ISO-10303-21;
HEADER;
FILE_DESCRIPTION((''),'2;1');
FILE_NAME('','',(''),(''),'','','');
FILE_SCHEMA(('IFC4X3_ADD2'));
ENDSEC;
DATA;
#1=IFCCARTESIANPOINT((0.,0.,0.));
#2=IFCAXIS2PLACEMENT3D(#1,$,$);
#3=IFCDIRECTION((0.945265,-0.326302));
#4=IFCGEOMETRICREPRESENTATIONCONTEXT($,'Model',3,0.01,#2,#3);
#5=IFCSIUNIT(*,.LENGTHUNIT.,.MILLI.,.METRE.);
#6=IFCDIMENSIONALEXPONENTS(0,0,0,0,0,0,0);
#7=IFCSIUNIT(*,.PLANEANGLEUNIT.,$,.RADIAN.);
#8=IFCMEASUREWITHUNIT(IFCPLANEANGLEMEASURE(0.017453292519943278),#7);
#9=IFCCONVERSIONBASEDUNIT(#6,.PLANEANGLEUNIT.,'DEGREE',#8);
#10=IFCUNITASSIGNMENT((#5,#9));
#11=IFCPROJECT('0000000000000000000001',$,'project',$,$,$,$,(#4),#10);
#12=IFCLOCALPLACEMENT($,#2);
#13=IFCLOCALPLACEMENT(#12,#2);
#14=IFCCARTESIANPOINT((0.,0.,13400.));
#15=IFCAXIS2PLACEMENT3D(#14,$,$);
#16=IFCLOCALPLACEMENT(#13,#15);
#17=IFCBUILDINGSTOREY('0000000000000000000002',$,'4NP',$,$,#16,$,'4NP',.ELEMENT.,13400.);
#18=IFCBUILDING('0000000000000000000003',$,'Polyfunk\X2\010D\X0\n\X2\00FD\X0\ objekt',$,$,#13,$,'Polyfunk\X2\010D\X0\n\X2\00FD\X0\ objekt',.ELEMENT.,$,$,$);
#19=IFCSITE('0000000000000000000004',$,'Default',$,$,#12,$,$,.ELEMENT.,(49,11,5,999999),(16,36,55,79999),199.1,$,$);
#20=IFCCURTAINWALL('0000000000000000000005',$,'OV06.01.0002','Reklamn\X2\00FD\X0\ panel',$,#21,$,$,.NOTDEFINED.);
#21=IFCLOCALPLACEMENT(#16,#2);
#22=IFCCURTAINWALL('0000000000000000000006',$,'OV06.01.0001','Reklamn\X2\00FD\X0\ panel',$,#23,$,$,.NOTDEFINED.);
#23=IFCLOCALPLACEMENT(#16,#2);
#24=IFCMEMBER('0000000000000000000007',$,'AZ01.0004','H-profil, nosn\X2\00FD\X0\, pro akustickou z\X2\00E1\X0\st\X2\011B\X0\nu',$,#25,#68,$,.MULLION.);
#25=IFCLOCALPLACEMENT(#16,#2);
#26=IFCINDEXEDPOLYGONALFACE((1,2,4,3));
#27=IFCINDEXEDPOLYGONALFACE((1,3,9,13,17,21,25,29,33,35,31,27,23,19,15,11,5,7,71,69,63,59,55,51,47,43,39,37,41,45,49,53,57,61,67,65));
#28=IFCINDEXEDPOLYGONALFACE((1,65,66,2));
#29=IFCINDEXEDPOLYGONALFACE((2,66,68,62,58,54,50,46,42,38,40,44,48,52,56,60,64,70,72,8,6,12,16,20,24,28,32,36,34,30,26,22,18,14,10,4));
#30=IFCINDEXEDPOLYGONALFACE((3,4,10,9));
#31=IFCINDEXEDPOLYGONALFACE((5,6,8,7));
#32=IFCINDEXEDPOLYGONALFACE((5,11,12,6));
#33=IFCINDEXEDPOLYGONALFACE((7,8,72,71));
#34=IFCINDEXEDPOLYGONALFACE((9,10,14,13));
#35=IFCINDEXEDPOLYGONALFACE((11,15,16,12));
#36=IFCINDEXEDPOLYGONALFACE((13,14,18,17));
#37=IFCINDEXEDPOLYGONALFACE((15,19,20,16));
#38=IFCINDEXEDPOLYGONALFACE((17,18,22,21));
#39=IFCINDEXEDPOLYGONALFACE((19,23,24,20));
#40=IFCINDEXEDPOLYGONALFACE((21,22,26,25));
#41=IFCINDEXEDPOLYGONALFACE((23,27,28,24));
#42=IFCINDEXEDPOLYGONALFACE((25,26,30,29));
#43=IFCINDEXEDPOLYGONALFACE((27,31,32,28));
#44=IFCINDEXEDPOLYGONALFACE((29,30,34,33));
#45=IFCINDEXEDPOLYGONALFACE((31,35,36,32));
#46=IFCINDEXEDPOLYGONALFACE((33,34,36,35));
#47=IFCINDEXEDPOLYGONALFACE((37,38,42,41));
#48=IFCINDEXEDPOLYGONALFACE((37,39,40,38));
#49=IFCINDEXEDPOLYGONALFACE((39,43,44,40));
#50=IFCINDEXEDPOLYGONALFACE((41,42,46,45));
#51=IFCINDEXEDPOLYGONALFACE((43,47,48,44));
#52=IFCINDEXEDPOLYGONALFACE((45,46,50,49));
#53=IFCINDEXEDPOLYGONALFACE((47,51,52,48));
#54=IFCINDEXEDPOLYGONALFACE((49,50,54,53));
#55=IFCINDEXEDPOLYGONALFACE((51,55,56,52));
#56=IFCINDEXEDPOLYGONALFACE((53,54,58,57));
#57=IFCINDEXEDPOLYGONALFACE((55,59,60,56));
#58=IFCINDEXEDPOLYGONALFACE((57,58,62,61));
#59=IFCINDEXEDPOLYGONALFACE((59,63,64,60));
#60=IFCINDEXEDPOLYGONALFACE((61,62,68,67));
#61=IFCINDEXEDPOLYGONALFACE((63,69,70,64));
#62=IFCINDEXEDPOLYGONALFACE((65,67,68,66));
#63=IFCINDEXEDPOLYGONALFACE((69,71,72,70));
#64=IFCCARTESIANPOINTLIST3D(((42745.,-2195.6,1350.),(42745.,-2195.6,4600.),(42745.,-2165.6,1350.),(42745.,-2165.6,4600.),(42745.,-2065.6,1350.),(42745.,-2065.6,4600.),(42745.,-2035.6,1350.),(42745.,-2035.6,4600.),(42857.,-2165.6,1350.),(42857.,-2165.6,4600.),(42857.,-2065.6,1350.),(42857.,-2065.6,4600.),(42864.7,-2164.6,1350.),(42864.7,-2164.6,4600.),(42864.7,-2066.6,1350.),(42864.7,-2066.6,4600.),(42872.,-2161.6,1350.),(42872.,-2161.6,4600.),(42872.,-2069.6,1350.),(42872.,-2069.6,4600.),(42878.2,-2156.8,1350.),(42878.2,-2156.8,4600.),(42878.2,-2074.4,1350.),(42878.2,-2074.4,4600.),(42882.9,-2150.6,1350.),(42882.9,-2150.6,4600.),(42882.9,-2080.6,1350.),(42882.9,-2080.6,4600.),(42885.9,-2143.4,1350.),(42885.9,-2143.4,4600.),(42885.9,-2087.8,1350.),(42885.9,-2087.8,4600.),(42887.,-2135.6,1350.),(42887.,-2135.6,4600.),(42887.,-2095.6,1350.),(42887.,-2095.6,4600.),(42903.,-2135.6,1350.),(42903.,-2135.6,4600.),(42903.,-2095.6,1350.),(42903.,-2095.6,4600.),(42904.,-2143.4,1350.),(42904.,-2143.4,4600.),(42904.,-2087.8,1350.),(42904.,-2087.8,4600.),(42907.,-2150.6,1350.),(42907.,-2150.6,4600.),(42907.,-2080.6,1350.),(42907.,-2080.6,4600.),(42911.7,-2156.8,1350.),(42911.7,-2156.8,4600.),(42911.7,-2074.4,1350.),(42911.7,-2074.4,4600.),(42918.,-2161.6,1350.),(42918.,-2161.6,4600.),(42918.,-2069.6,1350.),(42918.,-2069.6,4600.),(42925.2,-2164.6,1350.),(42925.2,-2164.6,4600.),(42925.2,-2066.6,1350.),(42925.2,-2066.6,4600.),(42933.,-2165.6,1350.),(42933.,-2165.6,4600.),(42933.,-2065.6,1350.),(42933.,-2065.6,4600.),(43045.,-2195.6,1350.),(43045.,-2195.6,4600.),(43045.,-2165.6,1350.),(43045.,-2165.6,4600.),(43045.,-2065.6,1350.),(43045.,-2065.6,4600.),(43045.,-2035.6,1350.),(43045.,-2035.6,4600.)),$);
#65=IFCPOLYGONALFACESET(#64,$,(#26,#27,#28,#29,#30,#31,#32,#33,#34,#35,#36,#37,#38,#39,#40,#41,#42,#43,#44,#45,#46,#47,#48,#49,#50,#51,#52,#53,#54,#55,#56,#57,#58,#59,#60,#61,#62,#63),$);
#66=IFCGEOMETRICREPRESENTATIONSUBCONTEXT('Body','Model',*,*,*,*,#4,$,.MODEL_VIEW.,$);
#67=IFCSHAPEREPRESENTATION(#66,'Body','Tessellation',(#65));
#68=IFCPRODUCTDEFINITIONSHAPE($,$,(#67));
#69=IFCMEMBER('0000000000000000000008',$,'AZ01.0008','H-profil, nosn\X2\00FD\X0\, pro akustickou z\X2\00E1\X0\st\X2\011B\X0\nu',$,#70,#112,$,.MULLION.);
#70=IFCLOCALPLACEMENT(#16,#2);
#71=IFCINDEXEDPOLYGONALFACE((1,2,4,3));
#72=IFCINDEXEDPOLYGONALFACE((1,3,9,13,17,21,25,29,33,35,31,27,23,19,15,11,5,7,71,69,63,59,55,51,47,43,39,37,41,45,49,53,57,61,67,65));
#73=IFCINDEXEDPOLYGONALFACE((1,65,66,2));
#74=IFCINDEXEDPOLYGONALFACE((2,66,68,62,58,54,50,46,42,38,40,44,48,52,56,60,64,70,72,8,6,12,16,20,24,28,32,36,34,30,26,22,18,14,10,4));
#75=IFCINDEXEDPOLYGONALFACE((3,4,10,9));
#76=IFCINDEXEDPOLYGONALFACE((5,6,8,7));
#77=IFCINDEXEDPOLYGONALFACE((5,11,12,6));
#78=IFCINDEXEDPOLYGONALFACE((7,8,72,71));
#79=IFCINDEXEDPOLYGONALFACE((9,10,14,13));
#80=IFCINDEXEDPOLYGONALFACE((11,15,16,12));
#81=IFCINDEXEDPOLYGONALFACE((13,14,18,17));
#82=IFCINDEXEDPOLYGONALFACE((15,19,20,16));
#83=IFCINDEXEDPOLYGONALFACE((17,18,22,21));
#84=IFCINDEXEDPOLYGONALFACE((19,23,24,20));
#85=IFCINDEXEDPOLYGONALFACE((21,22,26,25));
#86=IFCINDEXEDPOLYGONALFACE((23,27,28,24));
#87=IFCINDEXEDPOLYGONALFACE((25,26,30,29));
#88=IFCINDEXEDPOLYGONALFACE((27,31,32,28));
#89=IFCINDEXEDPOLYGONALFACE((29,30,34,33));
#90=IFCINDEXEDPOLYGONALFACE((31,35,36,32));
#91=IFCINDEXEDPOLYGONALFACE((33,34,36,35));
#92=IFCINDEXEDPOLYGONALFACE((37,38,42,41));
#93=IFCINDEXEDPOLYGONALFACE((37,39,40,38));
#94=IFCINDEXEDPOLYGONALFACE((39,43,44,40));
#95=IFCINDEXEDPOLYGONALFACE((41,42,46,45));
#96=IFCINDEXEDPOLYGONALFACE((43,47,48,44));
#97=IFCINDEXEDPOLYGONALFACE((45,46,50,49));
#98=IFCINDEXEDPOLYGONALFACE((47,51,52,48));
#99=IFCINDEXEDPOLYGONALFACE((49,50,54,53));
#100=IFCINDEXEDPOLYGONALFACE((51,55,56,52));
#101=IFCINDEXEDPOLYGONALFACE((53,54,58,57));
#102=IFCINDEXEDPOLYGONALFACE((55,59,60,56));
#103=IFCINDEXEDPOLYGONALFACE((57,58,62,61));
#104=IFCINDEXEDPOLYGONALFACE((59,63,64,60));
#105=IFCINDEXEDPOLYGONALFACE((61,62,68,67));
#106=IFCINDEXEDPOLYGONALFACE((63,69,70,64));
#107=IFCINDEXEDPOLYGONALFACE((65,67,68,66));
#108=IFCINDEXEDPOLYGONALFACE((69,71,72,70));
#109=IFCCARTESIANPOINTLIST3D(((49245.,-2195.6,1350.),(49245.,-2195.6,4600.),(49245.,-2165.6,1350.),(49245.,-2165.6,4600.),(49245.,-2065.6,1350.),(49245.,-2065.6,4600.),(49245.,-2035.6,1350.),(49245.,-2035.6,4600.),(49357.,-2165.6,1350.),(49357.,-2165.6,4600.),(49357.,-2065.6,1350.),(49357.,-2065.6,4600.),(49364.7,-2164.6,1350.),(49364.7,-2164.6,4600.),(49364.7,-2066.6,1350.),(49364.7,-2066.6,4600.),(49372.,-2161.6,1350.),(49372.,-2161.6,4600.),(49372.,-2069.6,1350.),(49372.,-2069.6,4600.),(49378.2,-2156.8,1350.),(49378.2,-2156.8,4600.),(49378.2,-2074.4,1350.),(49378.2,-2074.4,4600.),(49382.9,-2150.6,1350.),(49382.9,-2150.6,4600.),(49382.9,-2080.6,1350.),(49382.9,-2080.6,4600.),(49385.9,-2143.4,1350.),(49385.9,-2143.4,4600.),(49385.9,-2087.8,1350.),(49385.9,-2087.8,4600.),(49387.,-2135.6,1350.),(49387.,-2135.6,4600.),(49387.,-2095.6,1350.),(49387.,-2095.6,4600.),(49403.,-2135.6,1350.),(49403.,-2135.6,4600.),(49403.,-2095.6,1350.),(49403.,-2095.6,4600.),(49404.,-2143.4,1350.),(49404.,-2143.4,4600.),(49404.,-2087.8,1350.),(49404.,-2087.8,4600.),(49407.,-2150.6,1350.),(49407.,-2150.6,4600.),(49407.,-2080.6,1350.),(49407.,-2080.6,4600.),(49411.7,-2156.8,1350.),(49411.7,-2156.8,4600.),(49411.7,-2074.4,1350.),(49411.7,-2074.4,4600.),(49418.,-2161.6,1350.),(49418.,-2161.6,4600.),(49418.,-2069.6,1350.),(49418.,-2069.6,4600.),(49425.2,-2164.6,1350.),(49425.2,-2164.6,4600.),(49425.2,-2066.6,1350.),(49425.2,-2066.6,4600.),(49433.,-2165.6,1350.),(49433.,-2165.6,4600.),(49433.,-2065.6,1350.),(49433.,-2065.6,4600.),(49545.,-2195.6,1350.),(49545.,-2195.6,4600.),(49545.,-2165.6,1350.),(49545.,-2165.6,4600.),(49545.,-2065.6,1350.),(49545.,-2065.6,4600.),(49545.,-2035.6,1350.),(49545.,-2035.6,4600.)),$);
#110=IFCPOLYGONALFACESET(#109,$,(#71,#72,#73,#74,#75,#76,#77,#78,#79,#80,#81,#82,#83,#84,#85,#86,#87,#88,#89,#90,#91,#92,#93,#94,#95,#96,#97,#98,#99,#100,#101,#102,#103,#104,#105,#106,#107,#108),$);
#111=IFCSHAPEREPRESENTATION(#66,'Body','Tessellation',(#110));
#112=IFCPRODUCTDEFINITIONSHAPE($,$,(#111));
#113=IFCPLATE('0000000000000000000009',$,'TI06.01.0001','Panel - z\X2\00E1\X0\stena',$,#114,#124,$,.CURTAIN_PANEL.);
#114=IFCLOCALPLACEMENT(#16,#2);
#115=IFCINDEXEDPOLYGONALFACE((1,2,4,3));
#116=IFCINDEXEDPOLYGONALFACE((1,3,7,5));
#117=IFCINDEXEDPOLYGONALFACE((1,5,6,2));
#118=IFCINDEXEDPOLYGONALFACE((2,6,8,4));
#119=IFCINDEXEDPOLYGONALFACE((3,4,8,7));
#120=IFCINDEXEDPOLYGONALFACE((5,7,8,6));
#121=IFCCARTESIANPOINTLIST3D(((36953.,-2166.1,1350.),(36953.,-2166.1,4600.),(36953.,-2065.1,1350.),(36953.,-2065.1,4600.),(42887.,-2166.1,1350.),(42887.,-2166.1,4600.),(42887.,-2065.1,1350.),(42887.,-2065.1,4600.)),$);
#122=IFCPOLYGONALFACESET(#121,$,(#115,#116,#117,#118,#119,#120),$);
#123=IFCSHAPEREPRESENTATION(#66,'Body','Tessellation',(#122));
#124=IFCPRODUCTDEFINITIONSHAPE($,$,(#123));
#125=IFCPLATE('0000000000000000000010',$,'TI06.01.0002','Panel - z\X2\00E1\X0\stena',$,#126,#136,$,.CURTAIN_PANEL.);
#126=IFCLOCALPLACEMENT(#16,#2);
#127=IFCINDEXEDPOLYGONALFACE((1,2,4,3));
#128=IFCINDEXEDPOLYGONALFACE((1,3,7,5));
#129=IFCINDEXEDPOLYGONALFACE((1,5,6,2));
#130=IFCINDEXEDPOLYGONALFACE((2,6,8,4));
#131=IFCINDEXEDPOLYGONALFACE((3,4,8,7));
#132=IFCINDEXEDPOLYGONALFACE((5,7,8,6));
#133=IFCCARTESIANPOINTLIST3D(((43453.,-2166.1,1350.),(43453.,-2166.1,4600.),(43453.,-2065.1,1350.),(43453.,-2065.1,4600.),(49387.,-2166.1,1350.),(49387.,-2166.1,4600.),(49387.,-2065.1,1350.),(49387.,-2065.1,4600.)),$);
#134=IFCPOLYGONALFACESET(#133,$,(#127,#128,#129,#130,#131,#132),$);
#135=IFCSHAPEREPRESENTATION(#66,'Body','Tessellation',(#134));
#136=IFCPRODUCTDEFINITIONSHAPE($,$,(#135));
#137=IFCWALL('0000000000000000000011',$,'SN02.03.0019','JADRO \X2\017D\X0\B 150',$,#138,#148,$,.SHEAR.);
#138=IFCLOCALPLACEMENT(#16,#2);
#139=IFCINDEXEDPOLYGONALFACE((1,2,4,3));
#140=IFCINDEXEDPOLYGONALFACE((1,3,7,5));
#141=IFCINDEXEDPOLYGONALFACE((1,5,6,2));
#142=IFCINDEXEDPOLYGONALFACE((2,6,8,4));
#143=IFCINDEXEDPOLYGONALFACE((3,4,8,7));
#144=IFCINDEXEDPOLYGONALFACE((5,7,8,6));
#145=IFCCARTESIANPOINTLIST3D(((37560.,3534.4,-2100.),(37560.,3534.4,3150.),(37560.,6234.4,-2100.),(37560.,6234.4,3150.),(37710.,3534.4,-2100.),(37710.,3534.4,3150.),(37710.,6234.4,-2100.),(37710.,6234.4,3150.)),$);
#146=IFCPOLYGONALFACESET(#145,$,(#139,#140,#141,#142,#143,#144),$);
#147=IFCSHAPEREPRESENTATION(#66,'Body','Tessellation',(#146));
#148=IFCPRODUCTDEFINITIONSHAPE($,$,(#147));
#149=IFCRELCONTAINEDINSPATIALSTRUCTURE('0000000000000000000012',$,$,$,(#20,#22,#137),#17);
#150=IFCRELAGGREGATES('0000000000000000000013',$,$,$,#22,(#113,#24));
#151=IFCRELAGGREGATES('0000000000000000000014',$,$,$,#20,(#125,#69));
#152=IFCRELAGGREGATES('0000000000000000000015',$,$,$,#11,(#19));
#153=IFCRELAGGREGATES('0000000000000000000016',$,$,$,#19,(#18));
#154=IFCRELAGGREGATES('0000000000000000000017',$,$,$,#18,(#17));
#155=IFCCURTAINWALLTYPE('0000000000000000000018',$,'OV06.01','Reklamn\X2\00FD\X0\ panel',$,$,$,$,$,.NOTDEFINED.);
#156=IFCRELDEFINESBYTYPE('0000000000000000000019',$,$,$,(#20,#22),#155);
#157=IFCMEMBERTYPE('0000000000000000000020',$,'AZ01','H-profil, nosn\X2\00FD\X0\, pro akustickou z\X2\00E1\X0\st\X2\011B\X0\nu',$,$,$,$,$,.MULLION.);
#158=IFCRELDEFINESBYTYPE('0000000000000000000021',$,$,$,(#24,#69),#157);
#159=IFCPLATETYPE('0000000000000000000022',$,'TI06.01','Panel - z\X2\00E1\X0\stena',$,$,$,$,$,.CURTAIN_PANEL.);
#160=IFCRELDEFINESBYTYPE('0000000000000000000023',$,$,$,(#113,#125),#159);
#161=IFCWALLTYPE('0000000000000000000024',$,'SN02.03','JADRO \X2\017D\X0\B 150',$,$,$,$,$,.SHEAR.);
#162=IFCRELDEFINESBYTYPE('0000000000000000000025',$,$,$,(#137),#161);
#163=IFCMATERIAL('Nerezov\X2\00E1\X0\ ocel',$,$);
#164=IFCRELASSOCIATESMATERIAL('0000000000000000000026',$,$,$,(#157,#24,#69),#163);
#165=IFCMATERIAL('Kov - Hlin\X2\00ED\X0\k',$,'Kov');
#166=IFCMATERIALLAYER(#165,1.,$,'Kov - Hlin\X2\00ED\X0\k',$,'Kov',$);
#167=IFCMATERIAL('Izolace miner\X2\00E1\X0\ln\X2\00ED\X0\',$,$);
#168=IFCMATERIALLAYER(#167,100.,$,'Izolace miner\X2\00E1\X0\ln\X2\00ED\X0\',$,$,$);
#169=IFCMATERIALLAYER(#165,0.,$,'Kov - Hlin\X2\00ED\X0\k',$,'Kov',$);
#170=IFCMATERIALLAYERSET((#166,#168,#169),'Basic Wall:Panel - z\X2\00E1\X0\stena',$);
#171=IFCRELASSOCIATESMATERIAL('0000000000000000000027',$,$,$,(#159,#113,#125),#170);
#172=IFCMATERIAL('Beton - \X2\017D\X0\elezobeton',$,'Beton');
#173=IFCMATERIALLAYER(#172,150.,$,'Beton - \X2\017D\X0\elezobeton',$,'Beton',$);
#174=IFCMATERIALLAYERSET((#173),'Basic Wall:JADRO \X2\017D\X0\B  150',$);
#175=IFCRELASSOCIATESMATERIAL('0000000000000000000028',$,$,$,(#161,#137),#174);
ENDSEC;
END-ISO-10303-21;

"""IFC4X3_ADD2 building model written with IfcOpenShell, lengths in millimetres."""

from ifc_helpers import new_model, entity, si_unit, converted_unit, direction, frame, frame_2d, origin, place, context, subcontext, project, spatial, polyline, circle_curve, parameter, trimmed, segment, composite_curve, rectangle, outline, extrude, source, transform, mapped, material, layer, layer_set, layer_usage, material_profile, profile_set, profile_usage, type_object, element, aggregate, save


model = new_model("IFC4X3_ADD2")

# Units and contexts
model_context = context("Model", 3, precision=0.01, world=origin(), true_north=direction((0.945265, -0.326302)))
body_context = subcontext(model_context, "Body", "Model", "MODEL_VIEW")
ifc_project = project(units=[si_unit("LENGTHUNIT", "METRE", prefix="MILLI"), converted_unit("PLANEANGLEUNIT", "DEGREE", entity("IfcPlaneAngleMeasure", 0.017453292519943278), si_unit("PLANEANGLEUNIT", "RADIAN"), dimensions=[0, 0, 0, 0, 0, 0, 0])], contexts=[model_context])

# Site, building, storey
site_placement = place(None, origin())
site = spatial("IfcSite", under=ifc_project, at=site_placement, Name="Default", CompositionType="ELEMENT", RefLatitude=(49, 11, 5, 999999), RefLongitude=(16, 36, 55, 79999), RefElevation=199.1)
building_placement = place(site_placement, origin())
building = spatial("IfcBuilding", under=site, at=building_placement, Name="Polyfunkčný objekt", LongName="Polyfunkčný objekt", CompositionType="ELEMENT")
storey_placement = place(building_placement, frame((0.0, 0.0, 13400.0)))
storey = spatial("IfcBuildingStorey", under=building, at=storey_placement, Name="4NP", LongName="4NP", CompositionType="ELEMENT", Elevation=13400.0)

# Curtain walls
curtain_wall_type = type_object("IfcCurtainWallType", Name="OV06.01", Description="Reklamný panel", PredefinedType="NOTDEFINED")
curtain_wall_1_placement = place(storey_placement, frame((0.0, 0.0, -13400.0)))
curtain_wall_1 = element("IfcCurtainWall", 1, at=curtain_wall_1_placement, inside=storey, type_object=curtain_wall_type, Name="OV06.01.0002", Description="Reklamný panel", PredefinedType="NOTDEFINED")
ifc_material_1 = material(Name="Nerezová ocel")
ifc_material_profile = material_profile(ifc_material_1, outline(composite_curve([segment(polyline([(50.0, -150.0), (80.0, -150.0)]), True, "CONTINUOUS"), segment(polyline([(80.0, -150.0), (80.0, 150.0)]), True, "CONTINUOUS"), segment(polyline([(80.0, 150.0), (50.0, 150.0)]), True, "CONTINUOUS"), segment(polyline([(50.0, 150.0), (50.0, 38.0)]), True, "CONTINUOUS"), segment(trimmed(circle_curve(frame_2d((20.0, 38.0), x_axis=(0.0, 1.0)), 30.0), [parameter(180.0)], [parameter(270.0)], True, "PARAMETER"), False, "CONTINUOUS"), segment(polyline([(20.0, 8.0), (-20.0, 8.0)]), True, "CONTINUOUS"), segment(trimmed(circle_curve(frame_2d((-20.0, 38.0), x_axis=(0.0, 1.0)), 30.0), [parameter(90.0)], [parameter(180.0)], True, "PARAMETER"), False, "CONTINUOUS"), segment(polyline([(-50.0, 38.0), (-50.0, 150.0)]), True, "CONTINUOUS"), segment(polyline([(-50.0, 150.0), (-80.0, 150.0)]), True, "CONTINUOUS"), segment(polyline([(-80.0, 150.0), (-80.0, -150.0)]), True, "CONTINUOUS"), segment(polyline([(-80.0, -150.0), (-50.0, -150.0)]), True, "CONTINUOUS"), segment(polyline([(-50.0, -150.0), (-50.0, -38.0)]), True, "CONTINUOUS"), segment(trimmed(circle_curve(frame_2d((-20.0, -38.0), x_axis=(0.0, 1.0)), 30.0), [parameter(0.0)], [parameter(90.0)], True, "PARAMETER"), False, "CONTINUOUS"), segment(polyline([(-20.0, -8.0), (20.0, -8.0)]), True, "CONTINUOUS"), segment(trimmed(circle_curve(frame_2d((20.0, -38.0), x_axis=(0.0, 1.0)), 30.0), [parameter(270.0)], [parameter(0.0)], True, "PARAMETER"), False, "CONTINUOUS"), segment(polyline([(50.0, -38.0), (50.0, -150.0)]), True, "CONTINUOUS")], self_intersect=False)), Name="Profil zástena")
ifc_profile_set = profile_set([ifc_material_profile], Name="Profil zástena")
ifc_profile_usage = profile_usage(ifc_profile_set)
member_type_1 = type_object("IfcMemberType", Name="AZ01", Description="H-profil, nosný, pro akustickou zástěnu", PredefinedType="MULLION", material=ifc_profile_set)
curtain_wall_2_placement = place(storey_placement, frame((0.0, 0.0, -13400.0)))
curtain_wall_2 = element("IfcCurtainWall", 2, at=curtain_wall_2_placement, inside=storey, type_object=curtain_wall_type, Name="OV06.01.0001", Description="Reklamný panel", PredefinedType="NOTDEFINED")

# Members
shared_shape_1 = source(origin(), body_context, "Body", "SweptSolid", [
    extrude(outline(composite_curve([segment(polyline([(-150.0, -50.0), (-150.0, -80.0)]), True, "CONTINUOUS"), segment(polyline([(-150.0, -80.0), (150.0, -80.0)]), True, "CONTINUOUS"), segment(polyline([(150.0, -80.0), (150.0, -50.0)]), True, "CONTINUOUS"), segment(polyline([(150.0, -50.0), (38.0, -50.0)]), True, "CONTINUOUS"), segment(trimmed(circle_curve(frame_2d((38.0, -20.0), x_axis=(1.0, 0.0)), 30.0), [parameter(180.0)], [parameter(270.0)], True, "PARAMETER"), False, "CONTINUOUS"), segment(polyline([(8.0, -20.0), (8.0, 20.0)]), True, "CONTINUOUS"), segment(trimmed(circle_curve(frame_2d((38.0, 20.0), x_axis=(1.0, 0.0)), 30.0), [parameter(90.0)], [parameter(180.0)], True, "PARAMETER"), False, "CONTINUOUS"), segment(polyline([(38.0, 50.0), (150.0, 50.0)]), True, "CONTINUOUS"), segment(polyline([(150.0, 50.0), (150.0, 80.0)]), True, "CONTINUOUS"), segment(polyline([(150.0, 80.0), (-150.0, 80.0)]), True, "CONTINUOUS"), segment(polyline([(-150.0, 80.0), (-150.0, 50.0)]), True, "CONTINUOUS"), segment(polyline([(-150.0, 50.0), (-38.0, 50.0)]), True, "CONTINUOUS"), segment(trimmed(circle_curve(frame_2d((-38.0, 20.0), x_axis=(1.0, 0.0)), 30.0), [parameter(0.0)], [parameter(90.0)], True, "PARAMETER"), False, "CONTINUOUS"), segment(polyline([(-8.0, 20.0), (-8.0, -20.0)]), True, "CONTINUOUS"), segment(trimmed(circle_curve(frame_2d((-38.0, -20.0), x_axis=(1.0, 0.0)), 30.0), [parameter(270.0)], [parameter(0.0)], True, "PARAMETER"), False, "CONTINUOUS"), segment(polyline([(-38.0, -50.0), (-150.0, -50.0)]), True, "CONTINUOUS")], self_intersect=False)), frame((-150.0, 0.0, -3250.0), z_axis=(0.0, 0.0, -1.0), x_axis=(1.0, 0.0, 0.0)), (0.0, 0.0, -1.0), 3250.0),
])
member_1_placement = place(curtain_wall_2_placement, frame((43045.0, -2115.6, 14750.0), z_axis=(0.0, 0.0, -1.0), x_axis=(1.0, 0.0, 0.0)))
member_1 = element("IfcMember", 3, at=member_1_placement, type_object=member_type_1, material=ifc_profile_usage, Name="AZ01.0004", Description="H-profil, nosný, pro akustickou zástěnu", PredefinedType="MULLION", context=body_context, shape_type="MappedRepresentation", body=[
    mapped(shared_shape_1, transform((0.0, 0.0, 0.0), scale=1.0)),
])
member_2_placement = place(curtain_wall_1_placement, frame((49545.0, -2115.6, 14750.0), z_axis=(0.0, 0.0, -1.0), x_axis=(1.0, 0.0, 0.0)))
member_2 = element("IfcMember", 4, at=member_2_placement, type_object=member_type_1, material=ifc_profile_usage, Name="AZ01.0008", Description="H-profil, nosný, pro akustickou zástěnu", PredefinedType="MULLION", context=body_context, shape_type="MappedRepresentation", body=[
    mapped(shared_shape_1, transform((0.0, 0.0, 0.0), scale=1.0)),
])

# Plates
ifc_material_2 = material(Name="Kov - Hliník", Category="Kov")
ifc_layer_1 = layer(ifc_material_2, 1.0, Name="Kov - Hliník", Category="Kov")
ifc_material_3 = material(Name="Izolace minerální")
ifc_layer_2 = layer(ifc_material_3, 100.0, Name="Izolace minerální")
ifc_layer_3 = layer(ifc_material_2, 0.0, Name="Kov - Hliník", Category="Kov")
ifc_layer_set_1 = layer_set([ifc_layer_1, ifc_layer_2, ifc_layer_3], Name="Basic Wall:Panel - zástena")
ifc_layer_usage_1 = layer_usage(ifc_layer_set_1, "AXIS2", "NEGATIVE", 50.5)
plate_type = type_object("IfcPlateType", Name="TI06.01", Description="Panel - zástena", PredefinedType="CURTAIN_PANEL", material=ifc_layer_set_1)
plate_1_placement = place(storey_placement, frame((36953.0, -2115.6, 1350.0)))
plate_1 = element("IfcPlate", 5, at=plate_1_placement, type_object=plate_type, material=ifc_layer_usage_1, Name="TI06.01.0001", Description="Panel - zástena", PredefinedType="CURTAIN_PANEL", context=body_context, shape_type="SweptSolid", body=[
    extrude(rectangle(XDim=101.0, YDim=5934.0, at=frame_2d((0.0, 0.0), x_axis=(1.0, 0.0))), frame((2967.0, 0.0, 0.0), z_axis=(0.0, 0.0, 1.0), x_axis=(0.0, 1.0, 0.0)), (0.0, 0.0, 1.0), 3250.0),
])
aggregate(curtain_wall_2, [plate_1, member_1])
ifc_layer_usage_2 = layer_usage(ifc_layer_set_1, "AXIS2", "NEGATIVE", 50.5)
plate_2_placement = place(storey_placement, frame((43453.0, -2115.6, 1350.0)))
plate_2 = element("IfcPlate", 6, at=plate_2_placement, type_object=plate_type, material=ifc_layer_usage_2, Name="TI06.01.0002", Description="Panel - zástena", PredefinedType="CURTAIN_PANEL", context=body_context, shape_type="SweptSolid", body=[
    extrude(rectangle(XDim=101.0, YDim=5934.0, at=frame_2d((0.0, 0.0), x_axis=(1.0, 0.0))), frame((2967.0, 0.0, 0.0), z_axis=(0.0, 0.0, 1.0), x_axis=(0.0, 1.0, 0.0)), (0.0, 0.0, 1.0), 3250.0),
])
aggregate(curtain_wall_1, [plate_2, member_2])

# Wall
ifc_material_4 = material(Name="Beton - Železobeton", Category="Beton")
ifc_layer_4 = layer(ifc_material_4, 150.0, Name="Beton - Železobeton", Category="Beton")
ifc_layer_set_2 = layer_set([ifc_layer_4], Name="Basic Wall:JADRO ŽB  150")
wall_type = type_object("IfcWallType", Name="SN02.03", Description="JADRO ŽB 150", PredefinedType="SHEAR", material=ifc_layer_set_2)
wall_placement = place(storey_placement, frame((37635.0, 6234.4, -2100.0), z_axis=(0.0, 0.0, 1.0), x_axis=(0.0, -1.0, 0.0)))
element("IfcWall", 7, at=wall_placement, inside=storey, type_object=wall_type, material=ifc_layer_set_2, Name="SN02.03.0019", Description="JADRO ŽB 150", PredefinedType="SHEAR", context=body_context, shape_type="SweptSolid", body=[
    extrude(rectangle(XDim=2700.0, YDim=150.0, at=frame_2d((1350.0, 0.0), x_axis=(-1.0, 0.0))), origin(), (0.0, 0.0, 1.0), 5250.0),
])

save(model, "model.ifc")
